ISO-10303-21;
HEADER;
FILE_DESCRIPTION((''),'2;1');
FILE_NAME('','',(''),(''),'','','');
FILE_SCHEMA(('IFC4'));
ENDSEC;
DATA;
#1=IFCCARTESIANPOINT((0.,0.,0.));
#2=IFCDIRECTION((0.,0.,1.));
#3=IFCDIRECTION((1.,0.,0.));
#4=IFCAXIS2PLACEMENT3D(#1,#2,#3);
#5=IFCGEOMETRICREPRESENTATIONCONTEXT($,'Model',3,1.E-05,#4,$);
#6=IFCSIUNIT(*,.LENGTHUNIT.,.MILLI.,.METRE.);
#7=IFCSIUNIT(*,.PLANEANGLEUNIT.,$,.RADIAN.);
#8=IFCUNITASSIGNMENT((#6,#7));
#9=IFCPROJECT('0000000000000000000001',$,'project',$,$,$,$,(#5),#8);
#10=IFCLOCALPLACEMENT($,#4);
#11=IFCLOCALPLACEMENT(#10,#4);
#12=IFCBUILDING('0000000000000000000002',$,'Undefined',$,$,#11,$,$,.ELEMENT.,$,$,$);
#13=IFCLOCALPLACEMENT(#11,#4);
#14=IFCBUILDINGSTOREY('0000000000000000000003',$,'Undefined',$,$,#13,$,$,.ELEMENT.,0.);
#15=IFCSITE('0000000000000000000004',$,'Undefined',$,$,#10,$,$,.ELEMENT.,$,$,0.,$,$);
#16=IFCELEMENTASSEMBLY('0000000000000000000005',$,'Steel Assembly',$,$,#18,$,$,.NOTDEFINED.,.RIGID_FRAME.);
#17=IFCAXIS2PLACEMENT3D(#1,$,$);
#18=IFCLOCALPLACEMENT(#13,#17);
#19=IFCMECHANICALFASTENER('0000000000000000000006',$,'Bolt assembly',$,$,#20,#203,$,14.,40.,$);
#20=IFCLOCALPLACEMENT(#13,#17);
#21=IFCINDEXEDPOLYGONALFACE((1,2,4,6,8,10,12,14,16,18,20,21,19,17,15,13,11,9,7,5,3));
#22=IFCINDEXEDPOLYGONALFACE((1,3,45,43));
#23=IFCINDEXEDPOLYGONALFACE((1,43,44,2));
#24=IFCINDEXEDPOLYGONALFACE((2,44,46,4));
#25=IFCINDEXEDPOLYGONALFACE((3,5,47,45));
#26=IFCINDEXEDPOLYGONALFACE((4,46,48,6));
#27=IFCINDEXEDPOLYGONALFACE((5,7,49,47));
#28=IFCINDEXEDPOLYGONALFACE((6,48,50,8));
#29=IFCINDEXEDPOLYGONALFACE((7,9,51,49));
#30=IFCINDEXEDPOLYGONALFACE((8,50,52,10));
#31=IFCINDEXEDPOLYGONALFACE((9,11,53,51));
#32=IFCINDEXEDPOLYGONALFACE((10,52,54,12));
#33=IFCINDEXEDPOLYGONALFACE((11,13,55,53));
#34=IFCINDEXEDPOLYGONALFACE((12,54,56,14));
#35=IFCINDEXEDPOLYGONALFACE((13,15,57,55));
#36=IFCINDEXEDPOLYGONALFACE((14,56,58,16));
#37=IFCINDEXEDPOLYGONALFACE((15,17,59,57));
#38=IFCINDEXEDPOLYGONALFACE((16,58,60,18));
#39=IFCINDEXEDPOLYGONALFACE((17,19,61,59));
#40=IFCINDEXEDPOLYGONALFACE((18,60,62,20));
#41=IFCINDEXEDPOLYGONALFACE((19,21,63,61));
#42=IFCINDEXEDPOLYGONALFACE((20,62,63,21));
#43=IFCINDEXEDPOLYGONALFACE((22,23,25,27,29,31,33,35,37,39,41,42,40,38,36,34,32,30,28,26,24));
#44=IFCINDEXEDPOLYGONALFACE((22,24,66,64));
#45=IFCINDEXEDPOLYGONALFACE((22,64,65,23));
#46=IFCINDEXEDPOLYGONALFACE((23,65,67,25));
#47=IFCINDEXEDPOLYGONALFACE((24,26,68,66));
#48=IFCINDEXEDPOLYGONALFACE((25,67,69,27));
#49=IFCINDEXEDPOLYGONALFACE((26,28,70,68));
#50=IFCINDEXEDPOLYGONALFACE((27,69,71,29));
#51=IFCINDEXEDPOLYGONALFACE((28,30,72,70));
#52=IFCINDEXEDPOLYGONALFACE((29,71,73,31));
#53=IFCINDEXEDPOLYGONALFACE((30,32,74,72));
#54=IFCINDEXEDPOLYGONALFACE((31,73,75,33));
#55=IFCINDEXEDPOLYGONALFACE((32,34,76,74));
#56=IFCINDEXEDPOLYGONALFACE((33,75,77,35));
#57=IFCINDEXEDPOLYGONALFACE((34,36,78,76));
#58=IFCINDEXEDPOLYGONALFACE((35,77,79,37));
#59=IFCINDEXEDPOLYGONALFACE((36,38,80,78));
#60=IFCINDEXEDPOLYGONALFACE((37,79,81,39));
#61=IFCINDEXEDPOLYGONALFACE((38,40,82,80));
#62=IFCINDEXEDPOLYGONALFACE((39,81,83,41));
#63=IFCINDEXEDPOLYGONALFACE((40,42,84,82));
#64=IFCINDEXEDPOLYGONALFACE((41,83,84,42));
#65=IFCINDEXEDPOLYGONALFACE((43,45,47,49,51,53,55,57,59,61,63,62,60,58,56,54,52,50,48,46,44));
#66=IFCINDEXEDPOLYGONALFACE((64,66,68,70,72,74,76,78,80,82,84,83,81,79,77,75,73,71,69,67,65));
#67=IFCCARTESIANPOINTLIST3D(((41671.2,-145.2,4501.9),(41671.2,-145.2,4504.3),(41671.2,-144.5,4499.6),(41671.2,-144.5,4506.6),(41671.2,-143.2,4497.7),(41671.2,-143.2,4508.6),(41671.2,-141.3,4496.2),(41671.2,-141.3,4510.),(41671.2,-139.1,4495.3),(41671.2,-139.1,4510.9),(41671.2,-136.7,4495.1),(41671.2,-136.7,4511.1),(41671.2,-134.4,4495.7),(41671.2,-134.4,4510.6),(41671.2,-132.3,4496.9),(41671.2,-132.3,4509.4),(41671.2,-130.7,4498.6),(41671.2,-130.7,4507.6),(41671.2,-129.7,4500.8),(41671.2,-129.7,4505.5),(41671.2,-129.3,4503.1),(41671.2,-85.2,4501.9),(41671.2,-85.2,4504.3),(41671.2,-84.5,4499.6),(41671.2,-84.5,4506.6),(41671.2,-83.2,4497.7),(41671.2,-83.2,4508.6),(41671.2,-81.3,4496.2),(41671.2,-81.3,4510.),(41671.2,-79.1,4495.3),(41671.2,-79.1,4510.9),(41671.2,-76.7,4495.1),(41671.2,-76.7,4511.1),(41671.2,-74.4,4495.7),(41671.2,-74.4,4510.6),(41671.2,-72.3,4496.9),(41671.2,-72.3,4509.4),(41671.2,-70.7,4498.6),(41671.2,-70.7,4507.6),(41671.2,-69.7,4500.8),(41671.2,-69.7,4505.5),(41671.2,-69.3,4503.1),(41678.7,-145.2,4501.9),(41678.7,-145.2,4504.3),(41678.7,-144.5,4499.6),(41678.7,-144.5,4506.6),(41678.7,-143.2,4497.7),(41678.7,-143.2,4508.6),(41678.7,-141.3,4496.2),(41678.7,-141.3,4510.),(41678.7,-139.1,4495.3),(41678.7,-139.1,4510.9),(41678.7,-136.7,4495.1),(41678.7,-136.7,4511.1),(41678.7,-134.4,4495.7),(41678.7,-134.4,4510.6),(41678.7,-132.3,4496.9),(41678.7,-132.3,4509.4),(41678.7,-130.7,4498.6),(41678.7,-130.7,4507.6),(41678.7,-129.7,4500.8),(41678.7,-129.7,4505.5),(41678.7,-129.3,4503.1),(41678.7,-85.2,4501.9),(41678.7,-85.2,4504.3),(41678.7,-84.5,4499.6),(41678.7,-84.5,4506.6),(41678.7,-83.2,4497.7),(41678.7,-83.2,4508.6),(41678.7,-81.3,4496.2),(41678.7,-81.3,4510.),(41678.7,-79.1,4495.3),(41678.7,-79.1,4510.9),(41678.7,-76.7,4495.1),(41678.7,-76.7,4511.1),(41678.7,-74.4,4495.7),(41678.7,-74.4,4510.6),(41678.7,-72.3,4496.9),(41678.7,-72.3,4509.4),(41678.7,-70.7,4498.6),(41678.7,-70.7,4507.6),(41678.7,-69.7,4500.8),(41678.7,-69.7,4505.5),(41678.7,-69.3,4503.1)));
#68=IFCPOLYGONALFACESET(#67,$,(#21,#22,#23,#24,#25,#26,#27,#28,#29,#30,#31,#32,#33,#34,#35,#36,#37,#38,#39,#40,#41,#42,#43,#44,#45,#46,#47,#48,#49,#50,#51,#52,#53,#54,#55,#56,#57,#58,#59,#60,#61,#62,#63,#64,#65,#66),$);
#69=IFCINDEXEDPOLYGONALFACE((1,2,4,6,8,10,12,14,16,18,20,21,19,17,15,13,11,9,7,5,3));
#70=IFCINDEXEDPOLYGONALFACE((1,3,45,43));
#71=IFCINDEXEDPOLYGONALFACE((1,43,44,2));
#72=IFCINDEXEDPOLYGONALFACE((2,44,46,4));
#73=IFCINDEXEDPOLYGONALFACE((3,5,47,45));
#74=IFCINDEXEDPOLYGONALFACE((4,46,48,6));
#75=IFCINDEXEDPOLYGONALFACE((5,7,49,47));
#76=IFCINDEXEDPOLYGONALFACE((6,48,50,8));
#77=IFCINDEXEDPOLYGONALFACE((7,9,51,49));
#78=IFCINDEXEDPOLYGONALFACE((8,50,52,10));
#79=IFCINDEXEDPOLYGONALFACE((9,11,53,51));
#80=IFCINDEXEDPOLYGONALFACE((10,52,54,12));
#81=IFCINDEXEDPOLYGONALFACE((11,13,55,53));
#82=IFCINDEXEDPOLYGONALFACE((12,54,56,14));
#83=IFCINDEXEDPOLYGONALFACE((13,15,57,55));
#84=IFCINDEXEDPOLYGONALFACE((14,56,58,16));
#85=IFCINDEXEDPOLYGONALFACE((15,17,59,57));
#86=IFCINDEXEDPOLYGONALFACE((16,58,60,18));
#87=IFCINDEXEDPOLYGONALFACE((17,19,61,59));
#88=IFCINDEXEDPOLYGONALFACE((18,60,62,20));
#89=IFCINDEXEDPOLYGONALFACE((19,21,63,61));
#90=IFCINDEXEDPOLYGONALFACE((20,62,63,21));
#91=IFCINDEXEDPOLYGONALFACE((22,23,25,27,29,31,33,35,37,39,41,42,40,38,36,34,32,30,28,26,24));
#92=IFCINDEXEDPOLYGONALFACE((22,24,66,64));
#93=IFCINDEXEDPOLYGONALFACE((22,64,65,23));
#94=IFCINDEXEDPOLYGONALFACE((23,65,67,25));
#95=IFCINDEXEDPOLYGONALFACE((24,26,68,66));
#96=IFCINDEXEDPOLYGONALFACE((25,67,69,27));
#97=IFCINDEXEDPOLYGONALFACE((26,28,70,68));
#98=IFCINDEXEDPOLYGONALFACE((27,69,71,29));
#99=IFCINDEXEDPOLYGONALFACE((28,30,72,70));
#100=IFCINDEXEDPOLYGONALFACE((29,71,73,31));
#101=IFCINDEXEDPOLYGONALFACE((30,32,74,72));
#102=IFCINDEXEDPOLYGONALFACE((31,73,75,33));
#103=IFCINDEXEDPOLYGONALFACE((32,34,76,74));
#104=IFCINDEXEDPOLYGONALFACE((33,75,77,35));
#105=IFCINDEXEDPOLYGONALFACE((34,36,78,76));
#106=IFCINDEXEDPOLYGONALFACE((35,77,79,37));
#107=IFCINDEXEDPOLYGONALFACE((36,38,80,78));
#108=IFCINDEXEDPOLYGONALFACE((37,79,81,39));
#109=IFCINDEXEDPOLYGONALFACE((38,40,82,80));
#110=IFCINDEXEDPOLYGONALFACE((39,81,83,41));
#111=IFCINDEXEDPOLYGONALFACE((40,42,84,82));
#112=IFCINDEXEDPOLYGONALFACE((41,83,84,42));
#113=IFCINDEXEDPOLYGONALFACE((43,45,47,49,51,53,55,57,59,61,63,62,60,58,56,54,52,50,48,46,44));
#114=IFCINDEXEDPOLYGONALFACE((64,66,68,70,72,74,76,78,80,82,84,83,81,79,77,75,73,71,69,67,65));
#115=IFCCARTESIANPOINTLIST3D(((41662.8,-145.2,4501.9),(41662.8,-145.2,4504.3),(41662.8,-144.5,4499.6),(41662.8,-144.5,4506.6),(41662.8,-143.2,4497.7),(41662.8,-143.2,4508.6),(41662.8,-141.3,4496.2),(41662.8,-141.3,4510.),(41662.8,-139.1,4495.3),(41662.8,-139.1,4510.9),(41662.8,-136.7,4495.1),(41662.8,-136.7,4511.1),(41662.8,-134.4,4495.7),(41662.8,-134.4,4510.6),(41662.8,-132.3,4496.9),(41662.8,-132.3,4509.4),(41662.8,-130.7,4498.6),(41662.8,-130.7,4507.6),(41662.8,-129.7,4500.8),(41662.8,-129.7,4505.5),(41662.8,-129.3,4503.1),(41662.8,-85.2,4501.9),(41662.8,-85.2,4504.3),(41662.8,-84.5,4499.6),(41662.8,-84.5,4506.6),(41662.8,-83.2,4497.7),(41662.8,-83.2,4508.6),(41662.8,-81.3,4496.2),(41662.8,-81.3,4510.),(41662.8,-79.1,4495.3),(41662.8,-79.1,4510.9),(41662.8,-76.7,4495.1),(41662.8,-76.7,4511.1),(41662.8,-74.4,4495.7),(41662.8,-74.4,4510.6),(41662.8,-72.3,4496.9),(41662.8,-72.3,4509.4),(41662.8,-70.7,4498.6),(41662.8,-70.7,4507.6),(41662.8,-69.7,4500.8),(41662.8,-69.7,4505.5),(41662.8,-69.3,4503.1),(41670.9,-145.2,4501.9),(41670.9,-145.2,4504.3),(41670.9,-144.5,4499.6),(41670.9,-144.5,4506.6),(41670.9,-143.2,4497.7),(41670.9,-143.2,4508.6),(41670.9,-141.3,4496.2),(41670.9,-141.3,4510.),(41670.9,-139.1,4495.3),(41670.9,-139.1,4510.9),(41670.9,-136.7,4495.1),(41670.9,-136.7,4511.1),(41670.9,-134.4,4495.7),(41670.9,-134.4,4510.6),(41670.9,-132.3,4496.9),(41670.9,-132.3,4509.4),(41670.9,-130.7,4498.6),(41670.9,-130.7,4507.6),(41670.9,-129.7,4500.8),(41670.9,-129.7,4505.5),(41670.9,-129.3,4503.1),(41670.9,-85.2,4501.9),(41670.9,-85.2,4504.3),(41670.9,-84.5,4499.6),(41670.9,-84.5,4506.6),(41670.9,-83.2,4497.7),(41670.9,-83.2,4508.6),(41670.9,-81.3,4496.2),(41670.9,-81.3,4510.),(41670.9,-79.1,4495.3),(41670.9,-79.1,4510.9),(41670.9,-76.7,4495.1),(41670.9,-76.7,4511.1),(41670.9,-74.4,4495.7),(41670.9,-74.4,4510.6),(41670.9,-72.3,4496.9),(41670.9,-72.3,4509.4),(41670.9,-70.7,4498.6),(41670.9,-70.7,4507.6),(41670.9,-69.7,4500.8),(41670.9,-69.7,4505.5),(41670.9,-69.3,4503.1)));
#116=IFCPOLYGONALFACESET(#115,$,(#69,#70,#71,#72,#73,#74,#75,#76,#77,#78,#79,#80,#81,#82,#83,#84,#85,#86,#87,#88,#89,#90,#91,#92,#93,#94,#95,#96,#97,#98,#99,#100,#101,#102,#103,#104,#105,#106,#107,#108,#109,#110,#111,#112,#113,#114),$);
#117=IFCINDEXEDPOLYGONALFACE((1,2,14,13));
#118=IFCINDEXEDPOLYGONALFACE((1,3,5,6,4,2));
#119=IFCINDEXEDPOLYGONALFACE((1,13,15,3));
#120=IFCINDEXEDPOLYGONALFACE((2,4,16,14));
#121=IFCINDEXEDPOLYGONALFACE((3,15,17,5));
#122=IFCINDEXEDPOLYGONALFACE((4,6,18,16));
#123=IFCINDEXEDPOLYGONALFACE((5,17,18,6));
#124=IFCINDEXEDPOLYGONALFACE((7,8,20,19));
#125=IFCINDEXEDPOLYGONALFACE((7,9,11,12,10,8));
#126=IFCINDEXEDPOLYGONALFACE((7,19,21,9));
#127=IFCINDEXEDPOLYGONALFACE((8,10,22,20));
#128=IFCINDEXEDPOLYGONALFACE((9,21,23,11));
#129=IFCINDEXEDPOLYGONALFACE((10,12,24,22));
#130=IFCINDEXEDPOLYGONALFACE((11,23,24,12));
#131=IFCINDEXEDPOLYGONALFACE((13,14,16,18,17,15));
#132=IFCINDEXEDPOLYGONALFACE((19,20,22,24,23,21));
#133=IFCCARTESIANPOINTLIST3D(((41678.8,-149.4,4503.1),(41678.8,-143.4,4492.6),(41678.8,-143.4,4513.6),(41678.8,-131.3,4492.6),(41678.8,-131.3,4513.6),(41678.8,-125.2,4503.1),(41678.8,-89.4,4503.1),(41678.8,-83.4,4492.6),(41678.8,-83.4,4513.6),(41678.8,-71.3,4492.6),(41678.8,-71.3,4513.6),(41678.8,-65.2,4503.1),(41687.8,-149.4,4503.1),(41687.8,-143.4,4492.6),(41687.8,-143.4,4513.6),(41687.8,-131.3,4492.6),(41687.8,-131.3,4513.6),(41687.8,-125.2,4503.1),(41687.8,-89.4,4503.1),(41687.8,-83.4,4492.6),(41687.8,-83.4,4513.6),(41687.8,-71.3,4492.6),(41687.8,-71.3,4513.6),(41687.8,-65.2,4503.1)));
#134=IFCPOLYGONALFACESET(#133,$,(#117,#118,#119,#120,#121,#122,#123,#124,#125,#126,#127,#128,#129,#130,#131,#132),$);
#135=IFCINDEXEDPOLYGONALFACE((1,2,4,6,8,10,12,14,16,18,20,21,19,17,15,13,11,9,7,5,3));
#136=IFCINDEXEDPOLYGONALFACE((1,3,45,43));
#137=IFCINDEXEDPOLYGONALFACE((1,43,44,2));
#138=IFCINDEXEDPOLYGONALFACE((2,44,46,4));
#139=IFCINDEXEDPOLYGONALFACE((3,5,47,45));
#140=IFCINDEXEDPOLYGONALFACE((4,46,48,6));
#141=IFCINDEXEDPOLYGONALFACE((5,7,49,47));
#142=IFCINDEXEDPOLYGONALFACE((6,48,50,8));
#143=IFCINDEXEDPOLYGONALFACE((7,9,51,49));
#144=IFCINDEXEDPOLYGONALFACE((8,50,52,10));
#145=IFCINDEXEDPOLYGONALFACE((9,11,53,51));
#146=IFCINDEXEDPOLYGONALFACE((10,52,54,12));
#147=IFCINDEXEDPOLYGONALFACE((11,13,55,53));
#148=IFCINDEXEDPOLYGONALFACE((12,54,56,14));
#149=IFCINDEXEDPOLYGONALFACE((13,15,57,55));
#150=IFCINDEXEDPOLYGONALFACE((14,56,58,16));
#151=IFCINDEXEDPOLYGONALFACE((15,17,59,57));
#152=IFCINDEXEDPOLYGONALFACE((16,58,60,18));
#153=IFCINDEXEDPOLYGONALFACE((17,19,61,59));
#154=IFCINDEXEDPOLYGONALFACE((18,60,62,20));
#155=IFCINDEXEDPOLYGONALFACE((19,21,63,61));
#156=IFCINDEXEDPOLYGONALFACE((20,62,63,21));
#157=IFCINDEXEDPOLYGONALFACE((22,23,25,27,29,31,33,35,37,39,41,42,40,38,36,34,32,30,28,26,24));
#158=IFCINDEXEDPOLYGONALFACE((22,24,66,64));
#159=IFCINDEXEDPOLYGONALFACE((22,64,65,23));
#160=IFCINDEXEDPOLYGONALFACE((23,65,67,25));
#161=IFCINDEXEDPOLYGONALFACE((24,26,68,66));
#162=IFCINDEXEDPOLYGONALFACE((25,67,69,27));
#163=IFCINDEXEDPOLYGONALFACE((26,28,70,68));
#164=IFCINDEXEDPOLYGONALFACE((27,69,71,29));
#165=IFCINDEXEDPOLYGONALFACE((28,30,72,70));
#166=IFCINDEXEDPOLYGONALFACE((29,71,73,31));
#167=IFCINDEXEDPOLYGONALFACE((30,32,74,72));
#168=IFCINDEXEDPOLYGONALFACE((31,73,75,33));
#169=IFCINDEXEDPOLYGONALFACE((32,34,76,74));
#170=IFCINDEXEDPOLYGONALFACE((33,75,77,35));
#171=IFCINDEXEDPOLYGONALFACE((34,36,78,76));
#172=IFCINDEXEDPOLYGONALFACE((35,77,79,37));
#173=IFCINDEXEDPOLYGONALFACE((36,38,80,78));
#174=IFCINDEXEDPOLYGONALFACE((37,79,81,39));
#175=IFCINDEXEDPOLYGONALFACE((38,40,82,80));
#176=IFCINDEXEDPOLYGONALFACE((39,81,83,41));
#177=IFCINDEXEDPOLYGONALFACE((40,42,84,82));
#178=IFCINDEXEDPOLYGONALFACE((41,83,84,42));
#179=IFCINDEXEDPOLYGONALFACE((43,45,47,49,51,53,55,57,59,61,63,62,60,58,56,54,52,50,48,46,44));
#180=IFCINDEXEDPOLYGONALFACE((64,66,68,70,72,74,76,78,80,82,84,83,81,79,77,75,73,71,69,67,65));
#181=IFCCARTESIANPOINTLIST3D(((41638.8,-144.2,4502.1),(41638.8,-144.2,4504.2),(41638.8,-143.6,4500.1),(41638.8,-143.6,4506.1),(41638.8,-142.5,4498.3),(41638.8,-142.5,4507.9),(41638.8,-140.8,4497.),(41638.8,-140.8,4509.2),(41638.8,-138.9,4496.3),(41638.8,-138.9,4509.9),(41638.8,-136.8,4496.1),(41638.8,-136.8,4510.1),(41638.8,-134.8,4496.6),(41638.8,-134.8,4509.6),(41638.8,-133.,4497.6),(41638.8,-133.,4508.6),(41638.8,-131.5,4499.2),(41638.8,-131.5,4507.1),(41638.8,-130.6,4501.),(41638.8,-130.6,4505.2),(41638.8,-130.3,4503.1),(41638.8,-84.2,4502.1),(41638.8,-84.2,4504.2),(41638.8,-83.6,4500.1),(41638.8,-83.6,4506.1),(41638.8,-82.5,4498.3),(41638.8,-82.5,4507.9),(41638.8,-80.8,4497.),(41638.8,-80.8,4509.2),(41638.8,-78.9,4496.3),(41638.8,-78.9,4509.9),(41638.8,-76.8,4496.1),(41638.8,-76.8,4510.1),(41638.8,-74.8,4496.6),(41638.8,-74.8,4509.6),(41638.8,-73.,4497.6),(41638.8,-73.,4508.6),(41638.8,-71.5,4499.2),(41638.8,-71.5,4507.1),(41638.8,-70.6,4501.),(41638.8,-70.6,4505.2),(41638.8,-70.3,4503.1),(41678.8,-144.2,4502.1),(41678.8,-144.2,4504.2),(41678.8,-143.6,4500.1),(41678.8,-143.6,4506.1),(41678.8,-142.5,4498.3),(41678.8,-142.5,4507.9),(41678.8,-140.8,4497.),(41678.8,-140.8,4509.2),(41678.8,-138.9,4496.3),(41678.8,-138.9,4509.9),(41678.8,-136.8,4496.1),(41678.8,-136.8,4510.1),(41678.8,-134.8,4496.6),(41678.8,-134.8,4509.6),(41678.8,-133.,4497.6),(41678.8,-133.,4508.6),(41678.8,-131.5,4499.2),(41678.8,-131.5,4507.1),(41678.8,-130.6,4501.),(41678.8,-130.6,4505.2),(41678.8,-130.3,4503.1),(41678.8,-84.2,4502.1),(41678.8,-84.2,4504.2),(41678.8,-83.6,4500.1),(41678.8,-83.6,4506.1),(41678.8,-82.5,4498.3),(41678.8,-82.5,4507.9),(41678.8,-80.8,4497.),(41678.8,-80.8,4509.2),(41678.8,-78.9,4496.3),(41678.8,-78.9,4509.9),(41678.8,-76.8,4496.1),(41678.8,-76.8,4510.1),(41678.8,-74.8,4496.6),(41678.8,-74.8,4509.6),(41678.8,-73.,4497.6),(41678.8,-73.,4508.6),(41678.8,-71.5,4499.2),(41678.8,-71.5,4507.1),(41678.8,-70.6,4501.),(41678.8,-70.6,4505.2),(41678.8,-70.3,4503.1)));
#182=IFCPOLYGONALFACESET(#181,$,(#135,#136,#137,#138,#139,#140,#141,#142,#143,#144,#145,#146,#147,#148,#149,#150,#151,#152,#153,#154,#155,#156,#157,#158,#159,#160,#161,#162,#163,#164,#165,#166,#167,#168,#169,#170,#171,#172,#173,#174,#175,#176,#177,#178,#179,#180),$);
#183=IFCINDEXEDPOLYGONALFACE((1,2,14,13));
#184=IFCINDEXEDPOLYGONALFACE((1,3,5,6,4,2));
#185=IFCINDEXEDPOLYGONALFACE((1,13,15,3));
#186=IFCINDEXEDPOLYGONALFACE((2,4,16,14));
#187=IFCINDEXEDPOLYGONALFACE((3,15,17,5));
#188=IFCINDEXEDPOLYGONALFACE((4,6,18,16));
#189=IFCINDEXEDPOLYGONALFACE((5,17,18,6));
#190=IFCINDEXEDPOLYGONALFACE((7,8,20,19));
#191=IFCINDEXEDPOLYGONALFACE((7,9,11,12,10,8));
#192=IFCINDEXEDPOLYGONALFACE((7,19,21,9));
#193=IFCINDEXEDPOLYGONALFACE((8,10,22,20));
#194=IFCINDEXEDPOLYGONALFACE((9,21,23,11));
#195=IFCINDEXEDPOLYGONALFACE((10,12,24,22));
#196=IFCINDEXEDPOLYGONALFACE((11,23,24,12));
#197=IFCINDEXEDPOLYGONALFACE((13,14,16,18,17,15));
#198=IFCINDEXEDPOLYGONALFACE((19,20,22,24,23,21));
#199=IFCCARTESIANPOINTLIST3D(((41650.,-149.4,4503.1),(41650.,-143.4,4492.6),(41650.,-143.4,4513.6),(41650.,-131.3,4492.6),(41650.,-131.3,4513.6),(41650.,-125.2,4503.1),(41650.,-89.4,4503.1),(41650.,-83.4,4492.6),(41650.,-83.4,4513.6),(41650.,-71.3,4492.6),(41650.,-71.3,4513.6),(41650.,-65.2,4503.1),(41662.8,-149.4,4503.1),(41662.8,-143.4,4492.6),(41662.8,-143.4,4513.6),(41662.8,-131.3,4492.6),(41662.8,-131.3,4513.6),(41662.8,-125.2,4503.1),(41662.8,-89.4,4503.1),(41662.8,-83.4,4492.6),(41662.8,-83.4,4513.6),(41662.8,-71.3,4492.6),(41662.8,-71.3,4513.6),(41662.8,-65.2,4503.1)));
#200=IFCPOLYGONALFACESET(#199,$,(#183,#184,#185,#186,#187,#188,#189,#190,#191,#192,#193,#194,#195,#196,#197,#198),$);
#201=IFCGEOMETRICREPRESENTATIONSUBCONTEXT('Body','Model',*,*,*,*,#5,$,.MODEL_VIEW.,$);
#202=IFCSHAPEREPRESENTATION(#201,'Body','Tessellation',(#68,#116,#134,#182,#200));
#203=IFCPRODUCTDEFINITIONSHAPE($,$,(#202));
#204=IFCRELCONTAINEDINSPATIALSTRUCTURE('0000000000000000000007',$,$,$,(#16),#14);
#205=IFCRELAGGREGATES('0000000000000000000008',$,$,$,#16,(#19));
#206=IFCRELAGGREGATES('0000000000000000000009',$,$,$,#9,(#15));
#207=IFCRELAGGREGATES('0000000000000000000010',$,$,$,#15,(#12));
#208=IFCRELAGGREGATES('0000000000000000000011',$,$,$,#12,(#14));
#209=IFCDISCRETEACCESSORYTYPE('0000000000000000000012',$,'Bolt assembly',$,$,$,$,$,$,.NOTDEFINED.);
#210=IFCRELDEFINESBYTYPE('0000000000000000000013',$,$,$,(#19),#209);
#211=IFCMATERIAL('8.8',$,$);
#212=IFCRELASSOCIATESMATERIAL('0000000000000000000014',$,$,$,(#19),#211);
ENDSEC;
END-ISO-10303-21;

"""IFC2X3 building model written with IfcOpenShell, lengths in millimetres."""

from ifc_helpers import new_model, si_unit, frame, origin_with_axes, origin_2d_with_axis, place, context, subcontext, project, spatial, polyline, circle, outline, extrude, source, transform, mapped, material, type_object, element, aggregate, save


model = new_model("IFC2X3")

# Units and contexts
model_context = context("Model", 3, precision=1e-05, world=origin_with_axes())
body_context = subcontext(model_context, "Body", "Model", "MODEL_VIEW")
ifc_project = project(units=[si_unit("LENGTHUNIT", "METRE", prefix="MILLI"), si_unit("PLANEANGLEUNIT", "RADIAN")], contexts=[model_context])

# Site, building, storey
site_placement = place(None, origin_with_axes())
site = spatial("IfcSite", under=ifc_project, at=site_placement, Name="Undefined", CompositionType="ELEMENT", RefElevation=0.0)
building_placement = place(site_placement, origin_with_axes())
building = spatial("IfcBuilding", under=site, at=building_placement, Name="Undefined", CompositionType="ELEMENT")
storey_placement = place(building_placement, origin_with_axes())
storey = spatial("IfcBuildingStorey", under=building, at=storey_placement, Name="Undefined", CompositionType="ELEMENT", Elevation=0.0)

# Element assembly
assembly_1_placement = place(storey_placement, origin_with_axes())
assembly_1 = element("IfcElementAssembly", 1, at=assembly_1_placement, inside=storey, Name="Steel Assembly", AssemblyPlace="NOTDEFINED", PredefinedType="RIGID_FRAME")

# Shared definitions
discrete_accessory_type_1 = type_object("IfcDiscreteAccessoryType", Name="Bolt assembly")

# Shared definitions
ifc_material_1 = material(Name="8.8")

# Mechanical fastener
shared_shape_1 = source(origin_with_axes(), body_context, "Body", "SweptSolid", [
    extrude(circle(Radius=8.0, at=origin_2d_with_axis()), frame((0.0, -15.9, 0.0), z_axis=(0.0, 1.0, 0.0), x_axis=(1.0, 0.0, 0.0)), (0.0, 0.0, 1.0), 7.5),
    extrude(circle(Radius=8.0, at=origin_2d_with_axis()), frame((0.0, -8.1, 0.0), z_axis=(0.0, 1.0, 0.0), x_axis=(1.0, 0.0, 0.0)), (0.0, 0.0, 1.0), 8.1),
    extrude(outline(polyline([(12.1, 0.0), (6.1, 10.5), (-6.1, 10.5), (-12.1, 0.0), (-6.1, -10.5), (6.1, -10.5), (12.1, 0.0)])), frame((0.0, -25.0, 0.0), z_axis=(0.0, 1.0, 0.0), x_axis=(1.0, 0.0, 0.0)), (0.0, 0.0, 1.0), 9.0),
    extrude(circle(Radius=7.0, at=origin_2d_with_axis()), frame((0.0, -16.0, 0.0), z_axis=(0.0, 1.0, 0.0), x_axis=(1.0, 0.0, 0.0)), (0.0, 0.0, 1.0), 40.0),
    extrude(outline(polyline([(12.1, 0.0), (6.1, 10.5), (-6.1, 10.5), (-12.1, 0.0), (-6.1, -10.5), (6.1, -10.5), (12.1, 0.0)])), frame((0.0, 0.0, 0.0), z_axis=(0.0, 1.0, 0.0), x_axis=(1.0, 0.0, 0.0)), (0.0, 0.0, 1.0), 12.8),
])
mechanical_fastener_1_placement = place(assembly_1_placement, frame((41662.8, -137.3, 4505.6), z_axis=(0.0, 0.0, 1.0), x_axis=(0.0, 1.0, 0.0)))
mechanical_fastener_1 = element("IfcMechanicalFastener", 2, at=mechanical_fastener_1_placement, type_object=discrete_accessory_type_1, material=ifc_material_1, Name="Bolt assembly", NominalDiameter=14.0, NominalLength=40.0, context=body_context, shape_type="MappedRepresentation", body=[
    mapped(shared_shape_1, transform((0.0, 0.0, -2.5))),
    mapped(shared_shape_1, transform((60.0, 0.0, -2.5))),
])
aggregate(assembly_1, [mechanical_fastener_1])

save(model, "model.ifc")
